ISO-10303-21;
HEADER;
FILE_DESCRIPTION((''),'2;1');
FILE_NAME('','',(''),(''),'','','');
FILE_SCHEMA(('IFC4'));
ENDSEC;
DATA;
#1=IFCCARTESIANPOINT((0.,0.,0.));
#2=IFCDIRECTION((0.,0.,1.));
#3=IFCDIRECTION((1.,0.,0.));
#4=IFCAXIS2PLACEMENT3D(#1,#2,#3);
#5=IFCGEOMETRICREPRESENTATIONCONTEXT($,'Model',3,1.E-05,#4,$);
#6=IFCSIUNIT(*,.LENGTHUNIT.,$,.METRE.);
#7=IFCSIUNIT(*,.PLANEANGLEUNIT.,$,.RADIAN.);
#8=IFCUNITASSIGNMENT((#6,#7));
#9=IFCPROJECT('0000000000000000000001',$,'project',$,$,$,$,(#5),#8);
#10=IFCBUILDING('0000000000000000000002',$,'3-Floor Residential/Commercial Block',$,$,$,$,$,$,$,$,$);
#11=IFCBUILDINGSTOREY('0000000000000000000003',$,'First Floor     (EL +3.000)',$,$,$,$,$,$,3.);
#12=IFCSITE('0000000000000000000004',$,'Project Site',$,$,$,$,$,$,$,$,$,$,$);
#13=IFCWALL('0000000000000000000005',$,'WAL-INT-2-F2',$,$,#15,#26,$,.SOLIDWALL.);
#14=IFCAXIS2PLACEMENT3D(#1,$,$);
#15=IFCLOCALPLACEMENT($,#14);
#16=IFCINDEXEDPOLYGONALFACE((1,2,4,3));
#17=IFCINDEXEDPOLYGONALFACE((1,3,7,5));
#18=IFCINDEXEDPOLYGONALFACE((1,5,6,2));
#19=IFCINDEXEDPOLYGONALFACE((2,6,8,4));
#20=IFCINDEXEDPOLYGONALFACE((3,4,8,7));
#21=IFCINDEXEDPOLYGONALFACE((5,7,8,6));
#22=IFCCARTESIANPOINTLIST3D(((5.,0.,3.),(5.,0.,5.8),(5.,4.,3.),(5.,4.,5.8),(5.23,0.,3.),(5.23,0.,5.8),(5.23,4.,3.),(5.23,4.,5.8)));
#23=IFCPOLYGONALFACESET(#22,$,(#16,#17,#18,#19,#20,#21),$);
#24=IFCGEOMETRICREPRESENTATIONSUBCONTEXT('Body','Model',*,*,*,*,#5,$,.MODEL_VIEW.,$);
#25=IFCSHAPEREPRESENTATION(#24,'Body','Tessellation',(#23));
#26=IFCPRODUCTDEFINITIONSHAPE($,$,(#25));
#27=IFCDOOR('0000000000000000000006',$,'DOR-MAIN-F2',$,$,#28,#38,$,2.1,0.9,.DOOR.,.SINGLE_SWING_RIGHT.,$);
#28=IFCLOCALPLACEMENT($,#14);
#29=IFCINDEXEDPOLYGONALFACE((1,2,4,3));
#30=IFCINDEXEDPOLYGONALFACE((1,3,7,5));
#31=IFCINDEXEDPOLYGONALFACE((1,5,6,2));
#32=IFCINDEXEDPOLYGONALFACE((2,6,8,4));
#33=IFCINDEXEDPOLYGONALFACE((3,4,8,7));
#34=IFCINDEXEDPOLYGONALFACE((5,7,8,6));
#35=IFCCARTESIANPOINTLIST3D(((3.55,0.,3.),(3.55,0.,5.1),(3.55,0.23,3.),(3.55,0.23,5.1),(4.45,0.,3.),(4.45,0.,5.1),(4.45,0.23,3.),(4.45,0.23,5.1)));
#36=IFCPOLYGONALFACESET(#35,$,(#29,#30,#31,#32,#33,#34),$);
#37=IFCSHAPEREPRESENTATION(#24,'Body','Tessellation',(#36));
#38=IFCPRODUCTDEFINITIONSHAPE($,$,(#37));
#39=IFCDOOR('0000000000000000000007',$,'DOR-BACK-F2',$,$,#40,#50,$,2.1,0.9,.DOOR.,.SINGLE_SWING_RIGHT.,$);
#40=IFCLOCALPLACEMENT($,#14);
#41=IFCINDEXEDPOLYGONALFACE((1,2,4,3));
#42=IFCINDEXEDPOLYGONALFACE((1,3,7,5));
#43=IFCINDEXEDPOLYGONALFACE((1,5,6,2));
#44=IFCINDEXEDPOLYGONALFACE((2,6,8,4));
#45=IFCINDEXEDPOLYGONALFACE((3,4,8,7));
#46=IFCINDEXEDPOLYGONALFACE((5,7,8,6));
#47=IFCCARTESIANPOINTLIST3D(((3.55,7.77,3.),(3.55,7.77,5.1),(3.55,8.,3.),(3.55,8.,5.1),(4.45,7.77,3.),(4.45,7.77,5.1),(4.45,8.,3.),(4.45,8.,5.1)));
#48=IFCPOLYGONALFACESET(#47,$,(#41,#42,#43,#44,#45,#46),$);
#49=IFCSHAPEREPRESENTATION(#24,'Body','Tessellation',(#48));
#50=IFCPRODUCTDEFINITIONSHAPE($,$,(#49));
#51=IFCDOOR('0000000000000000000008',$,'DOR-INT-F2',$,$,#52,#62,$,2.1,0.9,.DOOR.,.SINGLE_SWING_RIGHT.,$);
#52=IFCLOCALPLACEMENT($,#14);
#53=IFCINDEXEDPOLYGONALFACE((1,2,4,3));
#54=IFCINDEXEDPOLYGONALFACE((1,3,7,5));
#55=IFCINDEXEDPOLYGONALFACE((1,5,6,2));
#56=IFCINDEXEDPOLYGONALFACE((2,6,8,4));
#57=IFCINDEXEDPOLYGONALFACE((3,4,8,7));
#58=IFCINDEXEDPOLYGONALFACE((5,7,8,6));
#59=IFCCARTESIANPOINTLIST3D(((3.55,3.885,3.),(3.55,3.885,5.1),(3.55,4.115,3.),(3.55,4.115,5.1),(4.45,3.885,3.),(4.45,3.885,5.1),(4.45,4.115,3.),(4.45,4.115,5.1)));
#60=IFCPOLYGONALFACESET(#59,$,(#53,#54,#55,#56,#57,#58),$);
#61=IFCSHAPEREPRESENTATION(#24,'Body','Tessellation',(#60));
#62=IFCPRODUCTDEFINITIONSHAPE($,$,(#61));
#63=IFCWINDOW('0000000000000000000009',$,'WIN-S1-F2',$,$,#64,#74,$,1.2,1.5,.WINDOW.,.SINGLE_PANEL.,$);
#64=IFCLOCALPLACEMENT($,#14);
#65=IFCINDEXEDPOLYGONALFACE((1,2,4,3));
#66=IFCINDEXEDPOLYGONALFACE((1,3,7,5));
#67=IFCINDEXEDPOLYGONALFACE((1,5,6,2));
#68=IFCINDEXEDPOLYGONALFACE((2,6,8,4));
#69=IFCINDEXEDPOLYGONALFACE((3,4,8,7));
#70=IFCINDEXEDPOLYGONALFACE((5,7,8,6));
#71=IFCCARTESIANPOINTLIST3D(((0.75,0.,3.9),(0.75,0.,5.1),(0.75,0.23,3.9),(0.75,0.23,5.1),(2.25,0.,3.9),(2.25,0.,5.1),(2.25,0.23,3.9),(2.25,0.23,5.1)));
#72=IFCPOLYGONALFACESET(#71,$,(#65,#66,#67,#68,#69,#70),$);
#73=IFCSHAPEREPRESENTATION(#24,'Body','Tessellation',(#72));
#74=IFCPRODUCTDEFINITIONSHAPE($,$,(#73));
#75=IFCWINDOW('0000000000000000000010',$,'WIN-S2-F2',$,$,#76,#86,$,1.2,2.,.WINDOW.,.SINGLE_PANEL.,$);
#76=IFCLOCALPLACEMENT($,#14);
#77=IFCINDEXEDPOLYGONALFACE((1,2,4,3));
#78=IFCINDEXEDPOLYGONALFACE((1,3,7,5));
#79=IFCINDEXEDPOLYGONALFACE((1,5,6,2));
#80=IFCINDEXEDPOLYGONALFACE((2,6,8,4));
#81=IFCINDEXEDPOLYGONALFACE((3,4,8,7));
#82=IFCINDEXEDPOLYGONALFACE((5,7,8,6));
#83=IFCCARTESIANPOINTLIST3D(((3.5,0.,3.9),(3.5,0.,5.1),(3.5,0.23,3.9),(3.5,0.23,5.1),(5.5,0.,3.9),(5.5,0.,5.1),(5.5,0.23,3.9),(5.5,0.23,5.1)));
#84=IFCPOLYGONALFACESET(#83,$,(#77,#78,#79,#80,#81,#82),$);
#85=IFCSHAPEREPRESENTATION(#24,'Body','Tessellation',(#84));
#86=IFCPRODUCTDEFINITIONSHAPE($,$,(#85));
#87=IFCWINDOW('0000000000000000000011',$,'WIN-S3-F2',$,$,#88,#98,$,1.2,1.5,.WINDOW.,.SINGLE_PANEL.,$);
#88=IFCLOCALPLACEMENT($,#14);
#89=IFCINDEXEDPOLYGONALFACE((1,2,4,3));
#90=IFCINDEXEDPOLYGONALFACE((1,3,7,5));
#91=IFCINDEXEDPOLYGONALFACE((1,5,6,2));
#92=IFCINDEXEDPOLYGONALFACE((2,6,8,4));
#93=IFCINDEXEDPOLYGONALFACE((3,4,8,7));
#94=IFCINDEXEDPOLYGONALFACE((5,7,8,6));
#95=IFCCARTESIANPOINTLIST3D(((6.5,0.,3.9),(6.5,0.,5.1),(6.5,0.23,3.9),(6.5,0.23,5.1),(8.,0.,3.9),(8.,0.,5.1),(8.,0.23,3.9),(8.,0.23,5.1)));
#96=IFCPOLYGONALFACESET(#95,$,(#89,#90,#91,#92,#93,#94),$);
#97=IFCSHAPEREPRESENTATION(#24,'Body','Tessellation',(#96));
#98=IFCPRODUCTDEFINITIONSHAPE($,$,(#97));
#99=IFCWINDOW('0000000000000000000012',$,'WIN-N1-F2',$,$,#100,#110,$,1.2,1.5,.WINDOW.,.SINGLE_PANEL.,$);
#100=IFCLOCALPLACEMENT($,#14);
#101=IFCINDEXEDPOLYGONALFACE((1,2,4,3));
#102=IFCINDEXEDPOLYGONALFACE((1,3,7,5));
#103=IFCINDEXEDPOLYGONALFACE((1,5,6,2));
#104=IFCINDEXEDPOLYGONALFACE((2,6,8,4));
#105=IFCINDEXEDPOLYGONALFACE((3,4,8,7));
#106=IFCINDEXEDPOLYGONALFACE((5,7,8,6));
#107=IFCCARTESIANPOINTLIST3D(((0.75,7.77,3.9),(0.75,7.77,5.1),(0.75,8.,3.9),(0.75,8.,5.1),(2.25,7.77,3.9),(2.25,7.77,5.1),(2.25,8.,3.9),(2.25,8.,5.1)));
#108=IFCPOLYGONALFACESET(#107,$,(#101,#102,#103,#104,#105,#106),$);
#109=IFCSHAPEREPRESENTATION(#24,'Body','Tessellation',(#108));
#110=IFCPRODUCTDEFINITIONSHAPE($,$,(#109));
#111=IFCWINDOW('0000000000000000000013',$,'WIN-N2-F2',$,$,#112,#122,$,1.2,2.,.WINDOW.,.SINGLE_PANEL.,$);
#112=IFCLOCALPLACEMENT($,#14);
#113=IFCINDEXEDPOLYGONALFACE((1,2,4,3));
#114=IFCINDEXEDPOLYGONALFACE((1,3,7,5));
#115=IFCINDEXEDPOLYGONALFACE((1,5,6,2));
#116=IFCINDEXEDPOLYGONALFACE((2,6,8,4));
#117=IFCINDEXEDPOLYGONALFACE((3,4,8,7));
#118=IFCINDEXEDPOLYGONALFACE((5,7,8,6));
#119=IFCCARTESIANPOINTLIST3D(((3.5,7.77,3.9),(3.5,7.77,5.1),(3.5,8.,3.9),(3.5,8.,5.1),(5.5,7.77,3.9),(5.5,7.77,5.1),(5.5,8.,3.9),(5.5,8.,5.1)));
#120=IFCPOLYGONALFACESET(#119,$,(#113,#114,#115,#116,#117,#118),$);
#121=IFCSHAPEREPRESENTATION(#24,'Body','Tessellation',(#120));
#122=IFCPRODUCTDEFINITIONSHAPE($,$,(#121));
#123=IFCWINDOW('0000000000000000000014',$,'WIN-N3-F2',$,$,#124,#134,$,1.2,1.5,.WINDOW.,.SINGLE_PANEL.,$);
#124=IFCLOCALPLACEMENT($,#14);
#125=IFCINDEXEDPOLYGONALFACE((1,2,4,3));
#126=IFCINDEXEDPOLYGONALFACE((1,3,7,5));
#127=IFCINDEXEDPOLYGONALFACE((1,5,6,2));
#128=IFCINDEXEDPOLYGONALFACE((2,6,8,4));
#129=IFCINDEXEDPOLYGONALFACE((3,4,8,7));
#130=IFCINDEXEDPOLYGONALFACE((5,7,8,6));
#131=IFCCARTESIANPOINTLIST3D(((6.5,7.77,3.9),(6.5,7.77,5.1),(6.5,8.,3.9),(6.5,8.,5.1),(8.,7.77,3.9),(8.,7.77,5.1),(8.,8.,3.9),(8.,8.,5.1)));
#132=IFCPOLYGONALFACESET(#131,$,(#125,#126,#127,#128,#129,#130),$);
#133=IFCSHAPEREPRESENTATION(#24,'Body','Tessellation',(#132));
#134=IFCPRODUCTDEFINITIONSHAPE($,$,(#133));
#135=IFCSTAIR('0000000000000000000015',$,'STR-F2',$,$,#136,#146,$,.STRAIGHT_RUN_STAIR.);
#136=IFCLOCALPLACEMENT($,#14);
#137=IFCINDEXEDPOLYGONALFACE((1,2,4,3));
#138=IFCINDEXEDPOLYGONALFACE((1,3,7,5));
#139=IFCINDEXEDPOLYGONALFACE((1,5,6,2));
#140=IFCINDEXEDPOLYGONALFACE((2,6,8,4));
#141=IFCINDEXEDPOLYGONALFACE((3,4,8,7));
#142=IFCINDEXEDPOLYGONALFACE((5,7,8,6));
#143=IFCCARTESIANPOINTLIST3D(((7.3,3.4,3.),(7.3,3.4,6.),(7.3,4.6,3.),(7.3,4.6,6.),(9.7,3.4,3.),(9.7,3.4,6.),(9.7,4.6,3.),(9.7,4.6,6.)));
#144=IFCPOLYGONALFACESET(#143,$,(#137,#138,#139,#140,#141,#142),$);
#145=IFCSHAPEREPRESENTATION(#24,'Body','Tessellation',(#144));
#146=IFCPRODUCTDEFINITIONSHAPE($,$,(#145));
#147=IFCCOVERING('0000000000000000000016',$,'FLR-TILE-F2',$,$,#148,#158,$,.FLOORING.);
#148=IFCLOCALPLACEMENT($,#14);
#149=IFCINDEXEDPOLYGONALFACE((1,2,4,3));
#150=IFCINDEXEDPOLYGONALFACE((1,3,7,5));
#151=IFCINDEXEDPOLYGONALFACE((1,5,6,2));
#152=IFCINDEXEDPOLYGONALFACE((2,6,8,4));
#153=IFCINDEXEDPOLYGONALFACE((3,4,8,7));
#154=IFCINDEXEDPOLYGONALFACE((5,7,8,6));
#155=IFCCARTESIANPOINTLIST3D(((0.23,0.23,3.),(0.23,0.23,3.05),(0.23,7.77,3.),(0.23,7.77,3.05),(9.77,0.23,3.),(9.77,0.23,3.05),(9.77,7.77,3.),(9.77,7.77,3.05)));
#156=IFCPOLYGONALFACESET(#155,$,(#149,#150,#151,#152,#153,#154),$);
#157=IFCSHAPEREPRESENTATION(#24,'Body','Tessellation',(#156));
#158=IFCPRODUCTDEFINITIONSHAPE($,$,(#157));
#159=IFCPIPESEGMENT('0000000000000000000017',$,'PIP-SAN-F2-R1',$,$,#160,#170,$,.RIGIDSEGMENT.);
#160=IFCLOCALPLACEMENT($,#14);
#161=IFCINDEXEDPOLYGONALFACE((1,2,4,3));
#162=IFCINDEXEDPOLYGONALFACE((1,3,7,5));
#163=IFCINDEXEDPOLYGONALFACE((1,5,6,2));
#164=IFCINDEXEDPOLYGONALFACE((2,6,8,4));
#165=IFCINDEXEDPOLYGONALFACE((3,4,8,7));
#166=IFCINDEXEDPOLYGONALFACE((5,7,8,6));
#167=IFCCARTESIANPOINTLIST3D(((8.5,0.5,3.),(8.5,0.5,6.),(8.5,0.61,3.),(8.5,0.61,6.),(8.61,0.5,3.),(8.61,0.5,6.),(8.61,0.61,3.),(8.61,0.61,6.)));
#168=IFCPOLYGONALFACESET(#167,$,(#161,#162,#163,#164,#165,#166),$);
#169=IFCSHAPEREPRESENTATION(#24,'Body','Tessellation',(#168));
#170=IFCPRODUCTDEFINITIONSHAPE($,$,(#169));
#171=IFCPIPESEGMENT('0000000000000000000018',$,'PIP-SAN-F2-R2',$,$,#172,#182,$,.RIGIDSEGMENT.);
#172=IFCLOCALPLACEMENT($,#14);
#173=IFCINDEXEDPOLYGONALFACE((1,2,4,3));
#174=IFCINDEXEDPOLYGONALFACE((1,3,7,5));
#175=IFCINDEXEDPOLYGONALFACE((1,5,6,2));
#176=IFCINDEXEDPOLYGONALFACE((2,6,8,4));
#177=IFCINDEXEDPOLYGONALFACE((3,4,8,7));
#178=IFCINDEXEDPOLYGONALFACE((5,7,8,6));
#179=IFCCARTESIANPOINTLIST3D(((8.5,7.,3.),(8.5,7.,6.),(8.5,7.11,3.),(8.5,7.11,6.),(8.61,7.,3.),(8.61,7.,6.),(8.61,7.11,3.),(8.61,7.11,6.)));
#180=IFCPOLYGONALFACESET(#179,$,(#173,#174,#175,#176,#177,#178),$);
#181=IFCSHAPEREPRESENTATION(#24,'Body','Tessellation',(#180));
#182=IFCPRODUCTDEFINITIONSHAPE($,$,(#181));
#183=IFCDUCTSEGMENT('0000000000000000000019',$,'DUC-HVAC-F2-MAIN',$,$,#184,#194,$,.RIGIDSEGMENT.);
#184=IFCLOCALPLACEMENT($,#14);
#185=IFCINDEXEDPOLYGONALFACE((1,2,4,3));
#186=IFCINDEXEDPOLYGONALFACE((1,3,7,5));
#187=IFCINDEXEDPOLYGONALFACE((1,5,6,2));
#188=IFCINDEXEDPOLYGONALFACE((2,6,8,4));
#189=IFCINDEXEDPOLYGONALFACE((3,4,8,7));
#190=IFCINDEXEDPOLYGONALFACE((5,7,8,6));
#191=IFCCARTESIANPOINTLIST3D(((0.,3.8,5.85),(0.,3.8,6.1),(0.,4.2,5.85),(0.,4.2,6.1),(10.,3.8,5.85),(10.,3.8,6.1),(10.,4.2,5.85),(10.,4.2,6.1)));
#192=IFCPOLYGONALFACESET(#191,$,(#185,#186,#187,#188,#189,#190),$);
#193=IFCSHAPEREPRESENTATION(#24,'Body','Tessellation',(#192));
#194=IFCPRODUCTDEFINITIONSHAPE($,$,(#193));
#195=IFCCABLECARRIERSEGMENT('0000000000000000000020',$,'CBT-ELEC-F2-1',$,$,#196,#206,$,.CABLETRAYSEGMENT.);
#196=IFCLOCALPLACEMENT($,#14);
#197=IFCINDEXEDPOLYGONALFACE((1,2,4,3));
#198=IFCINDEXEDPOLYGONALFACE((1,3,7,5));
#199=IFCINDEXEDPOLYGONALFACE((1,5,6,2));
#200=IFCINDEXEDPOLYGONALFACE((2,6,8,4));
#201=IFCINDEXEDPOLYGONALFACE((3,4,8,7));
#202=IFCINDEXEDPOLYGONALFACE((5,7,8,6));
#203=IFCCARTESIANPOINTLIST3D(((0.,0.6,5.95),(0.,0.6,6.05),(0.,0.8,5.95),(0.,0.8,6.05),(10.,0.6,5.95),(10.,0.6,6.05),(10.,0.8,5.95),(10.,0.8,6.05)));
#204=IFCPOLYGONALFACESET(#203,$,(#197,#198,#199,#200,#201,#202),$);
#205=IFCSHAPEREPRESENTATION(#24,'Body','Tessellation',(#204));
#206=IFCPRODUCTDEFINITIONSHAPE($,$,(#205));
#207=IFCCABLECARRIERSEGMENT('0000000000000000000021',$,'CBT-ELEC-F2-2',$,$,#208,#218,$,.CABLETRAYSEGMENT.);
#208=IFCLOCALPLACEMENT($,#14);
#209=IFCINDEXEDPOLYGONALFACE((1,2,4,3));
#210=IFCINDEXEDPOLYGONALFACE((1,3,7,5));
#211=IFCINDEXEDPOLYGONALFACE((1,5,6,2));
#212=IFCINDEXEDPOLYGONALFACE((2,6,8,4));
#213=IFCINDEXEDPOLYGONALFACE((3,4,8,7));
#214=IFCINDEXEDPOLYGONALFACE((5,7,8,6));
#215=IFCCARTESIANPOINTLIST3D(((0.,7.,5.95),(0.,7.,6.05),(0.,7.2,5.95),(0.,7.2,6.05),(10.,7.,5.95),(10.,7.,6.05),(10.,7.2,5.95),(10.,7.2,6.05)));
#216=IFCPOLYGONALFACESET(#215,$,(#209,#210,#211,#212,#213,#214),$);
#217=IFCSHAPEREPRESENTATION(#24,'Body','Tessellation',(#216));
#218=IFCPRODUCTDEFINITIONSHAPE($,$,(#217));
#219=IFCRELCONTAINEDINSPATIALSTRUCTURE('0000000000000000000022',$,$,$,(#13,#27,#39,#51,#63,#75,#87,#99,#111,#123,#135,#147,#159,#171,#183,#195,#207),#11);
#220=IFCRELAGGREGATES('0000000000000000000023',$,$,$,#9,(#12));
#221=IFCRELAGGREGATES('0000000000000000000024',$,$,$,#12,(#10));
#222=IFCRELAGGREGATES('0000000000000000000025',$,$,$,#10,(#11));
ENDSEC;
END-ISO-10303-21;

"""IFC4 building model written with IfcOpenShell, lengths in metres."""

from ifc_helpers import new_model, si_unit, frame, frame_2d, origin_with_axes, place, context, subcontext, project, spatial, rectangle, extrude, element, save


model = new_model("IFC4")

# Units and contexts
model_context = context("Model", 3, precision=1e-05, world=origin_with_axes())
body_context = subcontext(model_context, "Body", "Model", "MODEL_VIEW")
ifc_project = project(units=[si_unit("LENGTHUNIT", "METRE"), si_unit("PLANEANGLEUNIT", "RADIAN")], contexts=[model_context])

# Site, building, storey
site = spatial("IfcSite", under=ifc_project, Name="Project Site")
building = spatial("IfcBuilding", under=site, Name="3-Floor Residential/Commercial Block")
storey = spatial("IfcBuildingStorey", under=building, Name="First Floor     (EL +3.000)", Elevation=3.0)

# Wall
wall_1_placement = place(None, frame((5.0, 0.0, 3.0), z_axis=(0.0, 0.0, 1.0), x_axis=(1.0, 0.0, 0.0)))
element("IfcWall", 1, at=wall_1_placement, inside=storey, Name="WAL-INT-2-F2", PredefinedType="SOLIDWALL", context=body_context, shape_type="SweptSolid", body=[
    extrude(rectangle(XDim=0.23, YDim=4.0, at=frame_2d((0.115, 2.0))), origin_with_axes(), (0.0, 0.0, 1.0), 2.8),
])

# Doors
for number, where, z_axis, x_axis, name in (
    (2, (3.55, 0.0, 3.0), (0.0, 0.0, 1.0), (1.0, 0.0, 0.0), "DOR-MAIN-F2"),
    (3, (3.55, 7.77, 3.0), (0.0, 0.0, 1.0), (1.0, 0.0, 0.0), "DOR-BACK-F2"),
    (4, (3.55, 3.885, 3.0), (0.0, 0.0, 1.0), (1.0, 0.0, 0.0), "DOR-INT-F2"),
):
    element("IfcDoor", number, at=place(None, frame(where, z_axis=z_axis, x_axis=x_axis)), inside=storey, Name=name, OperationType="SINGLE_SWING_RIGHT", OverallHeight=2.1, OverallWidth=0.9, PredefinedType="DOOR", context=body_context, shape_type="SweptSolid", body=[
        extrude(rectangle(XDim=0.9, YDim=0.23, at=frame_2d((0.45, 0.115))), origin_with_axes(), (0.0, 0.0, 1.0), 2.1),
    ])

# Windows
window_1_placement = place(None, frame((0.75, 0.0, 3.9), z_axis=(0.0, 0.0, 1.0), x_axis=(1.0, 0.0, 0.0)))
element("IfcWindow", 5, at=window_1_placement, inside=storey, Name="WIN-S1-F2", OverallHeight=1.2, OverallWidth=1.5, PartitioningType="SINGLE_PANEL", PredefinedType="WINDOW", context=body_context, shape_type="SweptSolid", body=[
    extrude(rectangle(XDim=1.5, YDim=0.23, at=frame_2d((0.75, 0.115))), origin_with_axes(), (0.0, 0.0, 1.0), 1.2),
])
window_2_placement = place(None, frame((3.5, 0.0, 3.9), z_axis=(0.0, 0.0, 1.0), x_axis=(1.0, 0.0, 0.0)))
element("IfcWindow", 6, at=window_2_placement, inside=storey, Name="WIN-S2-F2", OverallHeight=1.2, OverallWidth=2.0, PartitioningType="SINGLE_PANEL", PredefinedType="WINDOW", context=body_context, shape_type="SweptSolid", body=[
    extrude(rectangle(XDim=2.0, YDim=0.23, at=frame_2d((1.0, 0.115))), origin_with_axes(), (0.0, 0.0, 1.0), 1.2),
])
for number, where, z_axis, x_axis, name in (
    (7, (6.5, 0.0, 3.9), (0.0, 0.0, 1.0), (1.0, 0.0, 0.0), "WIN-S3-F2"),
    (8, (0.75, 7.77, 3.9), (0.0, 0.0, 1.0), (1.0, 0.0, 0.0), "WIN-N1-F2"),
):
    element("IfcWindow", number, at=place(None, frame(where, z_axis=z_axis, x_axis=x_axis)), inside=storey, Name=name, OverallHeight=1.2, OverallWidth=1.5, PartitioningType="SINGLE_PANEL", PredefinedType="WINDOW", context=body_context, shape_type="SweptSolid", body=[
        extrude(rectangle(XDim=1.5, YDim=0.23, at=frame_2d((0.75, 0.115))), origin_with_axes(), (0.0, 0.0, 1.0), 1.2),
    ])
window_3_placement = place(None, frame((3.5, 7.77, 3.9), z_axis=(0.0, 0.0, 1.0), x_axis=(1.0, 0.0, 0.0)))
element("IfcWindow", 9, at=window_3_placement, inside=storey, Name="WIN-N2-F2", OverallHeight=1.2, OverallWidth=2.0, PartitioningType="SINGLE_PANEL", PredefinedType="WINDOW", context=body_context, shape_type="SweptSolid", body=[
    extrude(rectangle(XDim=2.0, YDim=0.23, at=frame_2d((1.0, 0.115))), origin_with_axes(), (0.0, 0.0, 1.0), 1.2),
])
window_4_placement = place(None, frame((6.5, 7.77, 3.9), z_axis=(0.0, 0.0, 1.0), x_axis=(1.0, 0.0, 0.0)))
element("IfcWindow", 10, at=window_4_placement, inside=storey, Name="WIN-N3-F2", OverallHeight=1.2, OverallWidth=1.5, PartitioningType="SINGLE_PANEL", PredefinedType="WINDOW", context=body_context, shape_type="SweptSolid", body=[
    extrude(rectangle(XDim=1.5, YDim=0.23, at=frame_2d((0.75, 0.115))), origin_with_axes(), (0.0, 0.0, 1.0), 1.2),
])

# Stair
stair_placement = place(None, frame((7.3, 3.4, 3.0), z_axis=(0.0, 0.0, 1.0), x_axis=(1.0, 0.0, 0.0)))
element("IfcStair", 11, at=stair_placement, inside=storey, Name="STR-F2", PredefinedType="STRAIGHT_RUN_STAIR", context=body_context, shape_type="SweptSolid", body=[
    extrude(rectangle(XDim=2.4, YDim=1.2, at=frame_2d((1.2, 0.6))), origin_with_axes(), (0.0, 0.0, 1.0), 3.0),
])

# Covering
covering_placement = place(None, frame((0.23, 0.23, 3.0), z_axis=(0.0, 0.0, 1.0), x_axis=(1.0, 0.0, 0.0)))
element("IfcCovering", 12, at=covering_placement, inside=storey, Name="FLR-TILE-F2", PredefinedType="FLOORING", context=body_context, shape_type="SweptSolid", body=[
    extrude(rectangle(XDim=9.54, YDim=7.54, at=frame_2d((4.77, 3.77))), origin_with_axes(), (0.0, 0.0, 1.0), 0.05),
])

# Pipe segments
for number, where, z_axis, x_axis, name in (
    (13, (8.5, 0.5, 3.0), (0.0, 0.0, 1.0), (1.0, 0.0, 0.0), "PIP-SAN-F2-R1"),
    (14, (8.5, 7.0, 3.0), (0.0, 0.0, 1.0), (1.0, 0.0, 0.0), "PIP-SAN-F2-R2"),
):
    element("IfcPipeSegment", number, at=place(None, frame(where, z_axis=z_axis, x_axis=x_axis)), inside=storey, Name=name, PredefinedType="RIGIDSEGMENT", context=body_context, shape_type="SweptSolid", body=[
        extrude(rectangle(XDim=0.11, YDim=0.11, at=frame_2d((0.055, 0.055))), origin_with_axes(), (0.0, 0.0, 1.0), 3.0),
    ])

# Duct segment
duct_segment_placement = place(None, frame((0.0, 3.8, 5.85), z_axis=(0.0, 0.0, 1.0), x_axis=(1.0, 0.0, 0.0)))
element("IfcDuctSegment", 15, at=duct_segment_placement, inside=storey, Name="DUC-HVAC-F2-MAIN", PredefinedType="RIGIDSEGMENT", context=body_context, shape_type="SweptSolid", body=[
    extrude(rectangle(XDim=10.0, YDim=0.4, at=frame_2d((5.0, 0.2))), origin_with_axes(), (0.0, 0.0, 1.0), 0.25),
])

# Cable carrier segments
for number, where, z_axis, x_axis, name in (
    (16, (0.0, 0.6, 5.95), (0.0, 0.0, 1.0), (1.0, 0.0, 0.0), "CBT-ELEC-F2-1"),
    (17, (0.0, 7.0, 5.95), (0.0, 0.0, 1.0), (1.0, 0.0, 0.0), "CBT-ELEC-F2-2"),
):
    element("IfcCableCarrierSegment", number, at=place(None, frame(where, z_axis=z_axis, x_axis=x_axis)), inside=storey, Name=name, PredefinedType="CABLETRAYSEGMENT", context=body_context, shape_type="SweptSolid", body=[
        extrude(rectangle(XDim=10.0, YDim=0.2, at=frame_2d((5.0, 0.1))), origin_with_axes(), (0.0, 0.0, 1.0), 0.1),
    ])

save(model, "model.ifc")
